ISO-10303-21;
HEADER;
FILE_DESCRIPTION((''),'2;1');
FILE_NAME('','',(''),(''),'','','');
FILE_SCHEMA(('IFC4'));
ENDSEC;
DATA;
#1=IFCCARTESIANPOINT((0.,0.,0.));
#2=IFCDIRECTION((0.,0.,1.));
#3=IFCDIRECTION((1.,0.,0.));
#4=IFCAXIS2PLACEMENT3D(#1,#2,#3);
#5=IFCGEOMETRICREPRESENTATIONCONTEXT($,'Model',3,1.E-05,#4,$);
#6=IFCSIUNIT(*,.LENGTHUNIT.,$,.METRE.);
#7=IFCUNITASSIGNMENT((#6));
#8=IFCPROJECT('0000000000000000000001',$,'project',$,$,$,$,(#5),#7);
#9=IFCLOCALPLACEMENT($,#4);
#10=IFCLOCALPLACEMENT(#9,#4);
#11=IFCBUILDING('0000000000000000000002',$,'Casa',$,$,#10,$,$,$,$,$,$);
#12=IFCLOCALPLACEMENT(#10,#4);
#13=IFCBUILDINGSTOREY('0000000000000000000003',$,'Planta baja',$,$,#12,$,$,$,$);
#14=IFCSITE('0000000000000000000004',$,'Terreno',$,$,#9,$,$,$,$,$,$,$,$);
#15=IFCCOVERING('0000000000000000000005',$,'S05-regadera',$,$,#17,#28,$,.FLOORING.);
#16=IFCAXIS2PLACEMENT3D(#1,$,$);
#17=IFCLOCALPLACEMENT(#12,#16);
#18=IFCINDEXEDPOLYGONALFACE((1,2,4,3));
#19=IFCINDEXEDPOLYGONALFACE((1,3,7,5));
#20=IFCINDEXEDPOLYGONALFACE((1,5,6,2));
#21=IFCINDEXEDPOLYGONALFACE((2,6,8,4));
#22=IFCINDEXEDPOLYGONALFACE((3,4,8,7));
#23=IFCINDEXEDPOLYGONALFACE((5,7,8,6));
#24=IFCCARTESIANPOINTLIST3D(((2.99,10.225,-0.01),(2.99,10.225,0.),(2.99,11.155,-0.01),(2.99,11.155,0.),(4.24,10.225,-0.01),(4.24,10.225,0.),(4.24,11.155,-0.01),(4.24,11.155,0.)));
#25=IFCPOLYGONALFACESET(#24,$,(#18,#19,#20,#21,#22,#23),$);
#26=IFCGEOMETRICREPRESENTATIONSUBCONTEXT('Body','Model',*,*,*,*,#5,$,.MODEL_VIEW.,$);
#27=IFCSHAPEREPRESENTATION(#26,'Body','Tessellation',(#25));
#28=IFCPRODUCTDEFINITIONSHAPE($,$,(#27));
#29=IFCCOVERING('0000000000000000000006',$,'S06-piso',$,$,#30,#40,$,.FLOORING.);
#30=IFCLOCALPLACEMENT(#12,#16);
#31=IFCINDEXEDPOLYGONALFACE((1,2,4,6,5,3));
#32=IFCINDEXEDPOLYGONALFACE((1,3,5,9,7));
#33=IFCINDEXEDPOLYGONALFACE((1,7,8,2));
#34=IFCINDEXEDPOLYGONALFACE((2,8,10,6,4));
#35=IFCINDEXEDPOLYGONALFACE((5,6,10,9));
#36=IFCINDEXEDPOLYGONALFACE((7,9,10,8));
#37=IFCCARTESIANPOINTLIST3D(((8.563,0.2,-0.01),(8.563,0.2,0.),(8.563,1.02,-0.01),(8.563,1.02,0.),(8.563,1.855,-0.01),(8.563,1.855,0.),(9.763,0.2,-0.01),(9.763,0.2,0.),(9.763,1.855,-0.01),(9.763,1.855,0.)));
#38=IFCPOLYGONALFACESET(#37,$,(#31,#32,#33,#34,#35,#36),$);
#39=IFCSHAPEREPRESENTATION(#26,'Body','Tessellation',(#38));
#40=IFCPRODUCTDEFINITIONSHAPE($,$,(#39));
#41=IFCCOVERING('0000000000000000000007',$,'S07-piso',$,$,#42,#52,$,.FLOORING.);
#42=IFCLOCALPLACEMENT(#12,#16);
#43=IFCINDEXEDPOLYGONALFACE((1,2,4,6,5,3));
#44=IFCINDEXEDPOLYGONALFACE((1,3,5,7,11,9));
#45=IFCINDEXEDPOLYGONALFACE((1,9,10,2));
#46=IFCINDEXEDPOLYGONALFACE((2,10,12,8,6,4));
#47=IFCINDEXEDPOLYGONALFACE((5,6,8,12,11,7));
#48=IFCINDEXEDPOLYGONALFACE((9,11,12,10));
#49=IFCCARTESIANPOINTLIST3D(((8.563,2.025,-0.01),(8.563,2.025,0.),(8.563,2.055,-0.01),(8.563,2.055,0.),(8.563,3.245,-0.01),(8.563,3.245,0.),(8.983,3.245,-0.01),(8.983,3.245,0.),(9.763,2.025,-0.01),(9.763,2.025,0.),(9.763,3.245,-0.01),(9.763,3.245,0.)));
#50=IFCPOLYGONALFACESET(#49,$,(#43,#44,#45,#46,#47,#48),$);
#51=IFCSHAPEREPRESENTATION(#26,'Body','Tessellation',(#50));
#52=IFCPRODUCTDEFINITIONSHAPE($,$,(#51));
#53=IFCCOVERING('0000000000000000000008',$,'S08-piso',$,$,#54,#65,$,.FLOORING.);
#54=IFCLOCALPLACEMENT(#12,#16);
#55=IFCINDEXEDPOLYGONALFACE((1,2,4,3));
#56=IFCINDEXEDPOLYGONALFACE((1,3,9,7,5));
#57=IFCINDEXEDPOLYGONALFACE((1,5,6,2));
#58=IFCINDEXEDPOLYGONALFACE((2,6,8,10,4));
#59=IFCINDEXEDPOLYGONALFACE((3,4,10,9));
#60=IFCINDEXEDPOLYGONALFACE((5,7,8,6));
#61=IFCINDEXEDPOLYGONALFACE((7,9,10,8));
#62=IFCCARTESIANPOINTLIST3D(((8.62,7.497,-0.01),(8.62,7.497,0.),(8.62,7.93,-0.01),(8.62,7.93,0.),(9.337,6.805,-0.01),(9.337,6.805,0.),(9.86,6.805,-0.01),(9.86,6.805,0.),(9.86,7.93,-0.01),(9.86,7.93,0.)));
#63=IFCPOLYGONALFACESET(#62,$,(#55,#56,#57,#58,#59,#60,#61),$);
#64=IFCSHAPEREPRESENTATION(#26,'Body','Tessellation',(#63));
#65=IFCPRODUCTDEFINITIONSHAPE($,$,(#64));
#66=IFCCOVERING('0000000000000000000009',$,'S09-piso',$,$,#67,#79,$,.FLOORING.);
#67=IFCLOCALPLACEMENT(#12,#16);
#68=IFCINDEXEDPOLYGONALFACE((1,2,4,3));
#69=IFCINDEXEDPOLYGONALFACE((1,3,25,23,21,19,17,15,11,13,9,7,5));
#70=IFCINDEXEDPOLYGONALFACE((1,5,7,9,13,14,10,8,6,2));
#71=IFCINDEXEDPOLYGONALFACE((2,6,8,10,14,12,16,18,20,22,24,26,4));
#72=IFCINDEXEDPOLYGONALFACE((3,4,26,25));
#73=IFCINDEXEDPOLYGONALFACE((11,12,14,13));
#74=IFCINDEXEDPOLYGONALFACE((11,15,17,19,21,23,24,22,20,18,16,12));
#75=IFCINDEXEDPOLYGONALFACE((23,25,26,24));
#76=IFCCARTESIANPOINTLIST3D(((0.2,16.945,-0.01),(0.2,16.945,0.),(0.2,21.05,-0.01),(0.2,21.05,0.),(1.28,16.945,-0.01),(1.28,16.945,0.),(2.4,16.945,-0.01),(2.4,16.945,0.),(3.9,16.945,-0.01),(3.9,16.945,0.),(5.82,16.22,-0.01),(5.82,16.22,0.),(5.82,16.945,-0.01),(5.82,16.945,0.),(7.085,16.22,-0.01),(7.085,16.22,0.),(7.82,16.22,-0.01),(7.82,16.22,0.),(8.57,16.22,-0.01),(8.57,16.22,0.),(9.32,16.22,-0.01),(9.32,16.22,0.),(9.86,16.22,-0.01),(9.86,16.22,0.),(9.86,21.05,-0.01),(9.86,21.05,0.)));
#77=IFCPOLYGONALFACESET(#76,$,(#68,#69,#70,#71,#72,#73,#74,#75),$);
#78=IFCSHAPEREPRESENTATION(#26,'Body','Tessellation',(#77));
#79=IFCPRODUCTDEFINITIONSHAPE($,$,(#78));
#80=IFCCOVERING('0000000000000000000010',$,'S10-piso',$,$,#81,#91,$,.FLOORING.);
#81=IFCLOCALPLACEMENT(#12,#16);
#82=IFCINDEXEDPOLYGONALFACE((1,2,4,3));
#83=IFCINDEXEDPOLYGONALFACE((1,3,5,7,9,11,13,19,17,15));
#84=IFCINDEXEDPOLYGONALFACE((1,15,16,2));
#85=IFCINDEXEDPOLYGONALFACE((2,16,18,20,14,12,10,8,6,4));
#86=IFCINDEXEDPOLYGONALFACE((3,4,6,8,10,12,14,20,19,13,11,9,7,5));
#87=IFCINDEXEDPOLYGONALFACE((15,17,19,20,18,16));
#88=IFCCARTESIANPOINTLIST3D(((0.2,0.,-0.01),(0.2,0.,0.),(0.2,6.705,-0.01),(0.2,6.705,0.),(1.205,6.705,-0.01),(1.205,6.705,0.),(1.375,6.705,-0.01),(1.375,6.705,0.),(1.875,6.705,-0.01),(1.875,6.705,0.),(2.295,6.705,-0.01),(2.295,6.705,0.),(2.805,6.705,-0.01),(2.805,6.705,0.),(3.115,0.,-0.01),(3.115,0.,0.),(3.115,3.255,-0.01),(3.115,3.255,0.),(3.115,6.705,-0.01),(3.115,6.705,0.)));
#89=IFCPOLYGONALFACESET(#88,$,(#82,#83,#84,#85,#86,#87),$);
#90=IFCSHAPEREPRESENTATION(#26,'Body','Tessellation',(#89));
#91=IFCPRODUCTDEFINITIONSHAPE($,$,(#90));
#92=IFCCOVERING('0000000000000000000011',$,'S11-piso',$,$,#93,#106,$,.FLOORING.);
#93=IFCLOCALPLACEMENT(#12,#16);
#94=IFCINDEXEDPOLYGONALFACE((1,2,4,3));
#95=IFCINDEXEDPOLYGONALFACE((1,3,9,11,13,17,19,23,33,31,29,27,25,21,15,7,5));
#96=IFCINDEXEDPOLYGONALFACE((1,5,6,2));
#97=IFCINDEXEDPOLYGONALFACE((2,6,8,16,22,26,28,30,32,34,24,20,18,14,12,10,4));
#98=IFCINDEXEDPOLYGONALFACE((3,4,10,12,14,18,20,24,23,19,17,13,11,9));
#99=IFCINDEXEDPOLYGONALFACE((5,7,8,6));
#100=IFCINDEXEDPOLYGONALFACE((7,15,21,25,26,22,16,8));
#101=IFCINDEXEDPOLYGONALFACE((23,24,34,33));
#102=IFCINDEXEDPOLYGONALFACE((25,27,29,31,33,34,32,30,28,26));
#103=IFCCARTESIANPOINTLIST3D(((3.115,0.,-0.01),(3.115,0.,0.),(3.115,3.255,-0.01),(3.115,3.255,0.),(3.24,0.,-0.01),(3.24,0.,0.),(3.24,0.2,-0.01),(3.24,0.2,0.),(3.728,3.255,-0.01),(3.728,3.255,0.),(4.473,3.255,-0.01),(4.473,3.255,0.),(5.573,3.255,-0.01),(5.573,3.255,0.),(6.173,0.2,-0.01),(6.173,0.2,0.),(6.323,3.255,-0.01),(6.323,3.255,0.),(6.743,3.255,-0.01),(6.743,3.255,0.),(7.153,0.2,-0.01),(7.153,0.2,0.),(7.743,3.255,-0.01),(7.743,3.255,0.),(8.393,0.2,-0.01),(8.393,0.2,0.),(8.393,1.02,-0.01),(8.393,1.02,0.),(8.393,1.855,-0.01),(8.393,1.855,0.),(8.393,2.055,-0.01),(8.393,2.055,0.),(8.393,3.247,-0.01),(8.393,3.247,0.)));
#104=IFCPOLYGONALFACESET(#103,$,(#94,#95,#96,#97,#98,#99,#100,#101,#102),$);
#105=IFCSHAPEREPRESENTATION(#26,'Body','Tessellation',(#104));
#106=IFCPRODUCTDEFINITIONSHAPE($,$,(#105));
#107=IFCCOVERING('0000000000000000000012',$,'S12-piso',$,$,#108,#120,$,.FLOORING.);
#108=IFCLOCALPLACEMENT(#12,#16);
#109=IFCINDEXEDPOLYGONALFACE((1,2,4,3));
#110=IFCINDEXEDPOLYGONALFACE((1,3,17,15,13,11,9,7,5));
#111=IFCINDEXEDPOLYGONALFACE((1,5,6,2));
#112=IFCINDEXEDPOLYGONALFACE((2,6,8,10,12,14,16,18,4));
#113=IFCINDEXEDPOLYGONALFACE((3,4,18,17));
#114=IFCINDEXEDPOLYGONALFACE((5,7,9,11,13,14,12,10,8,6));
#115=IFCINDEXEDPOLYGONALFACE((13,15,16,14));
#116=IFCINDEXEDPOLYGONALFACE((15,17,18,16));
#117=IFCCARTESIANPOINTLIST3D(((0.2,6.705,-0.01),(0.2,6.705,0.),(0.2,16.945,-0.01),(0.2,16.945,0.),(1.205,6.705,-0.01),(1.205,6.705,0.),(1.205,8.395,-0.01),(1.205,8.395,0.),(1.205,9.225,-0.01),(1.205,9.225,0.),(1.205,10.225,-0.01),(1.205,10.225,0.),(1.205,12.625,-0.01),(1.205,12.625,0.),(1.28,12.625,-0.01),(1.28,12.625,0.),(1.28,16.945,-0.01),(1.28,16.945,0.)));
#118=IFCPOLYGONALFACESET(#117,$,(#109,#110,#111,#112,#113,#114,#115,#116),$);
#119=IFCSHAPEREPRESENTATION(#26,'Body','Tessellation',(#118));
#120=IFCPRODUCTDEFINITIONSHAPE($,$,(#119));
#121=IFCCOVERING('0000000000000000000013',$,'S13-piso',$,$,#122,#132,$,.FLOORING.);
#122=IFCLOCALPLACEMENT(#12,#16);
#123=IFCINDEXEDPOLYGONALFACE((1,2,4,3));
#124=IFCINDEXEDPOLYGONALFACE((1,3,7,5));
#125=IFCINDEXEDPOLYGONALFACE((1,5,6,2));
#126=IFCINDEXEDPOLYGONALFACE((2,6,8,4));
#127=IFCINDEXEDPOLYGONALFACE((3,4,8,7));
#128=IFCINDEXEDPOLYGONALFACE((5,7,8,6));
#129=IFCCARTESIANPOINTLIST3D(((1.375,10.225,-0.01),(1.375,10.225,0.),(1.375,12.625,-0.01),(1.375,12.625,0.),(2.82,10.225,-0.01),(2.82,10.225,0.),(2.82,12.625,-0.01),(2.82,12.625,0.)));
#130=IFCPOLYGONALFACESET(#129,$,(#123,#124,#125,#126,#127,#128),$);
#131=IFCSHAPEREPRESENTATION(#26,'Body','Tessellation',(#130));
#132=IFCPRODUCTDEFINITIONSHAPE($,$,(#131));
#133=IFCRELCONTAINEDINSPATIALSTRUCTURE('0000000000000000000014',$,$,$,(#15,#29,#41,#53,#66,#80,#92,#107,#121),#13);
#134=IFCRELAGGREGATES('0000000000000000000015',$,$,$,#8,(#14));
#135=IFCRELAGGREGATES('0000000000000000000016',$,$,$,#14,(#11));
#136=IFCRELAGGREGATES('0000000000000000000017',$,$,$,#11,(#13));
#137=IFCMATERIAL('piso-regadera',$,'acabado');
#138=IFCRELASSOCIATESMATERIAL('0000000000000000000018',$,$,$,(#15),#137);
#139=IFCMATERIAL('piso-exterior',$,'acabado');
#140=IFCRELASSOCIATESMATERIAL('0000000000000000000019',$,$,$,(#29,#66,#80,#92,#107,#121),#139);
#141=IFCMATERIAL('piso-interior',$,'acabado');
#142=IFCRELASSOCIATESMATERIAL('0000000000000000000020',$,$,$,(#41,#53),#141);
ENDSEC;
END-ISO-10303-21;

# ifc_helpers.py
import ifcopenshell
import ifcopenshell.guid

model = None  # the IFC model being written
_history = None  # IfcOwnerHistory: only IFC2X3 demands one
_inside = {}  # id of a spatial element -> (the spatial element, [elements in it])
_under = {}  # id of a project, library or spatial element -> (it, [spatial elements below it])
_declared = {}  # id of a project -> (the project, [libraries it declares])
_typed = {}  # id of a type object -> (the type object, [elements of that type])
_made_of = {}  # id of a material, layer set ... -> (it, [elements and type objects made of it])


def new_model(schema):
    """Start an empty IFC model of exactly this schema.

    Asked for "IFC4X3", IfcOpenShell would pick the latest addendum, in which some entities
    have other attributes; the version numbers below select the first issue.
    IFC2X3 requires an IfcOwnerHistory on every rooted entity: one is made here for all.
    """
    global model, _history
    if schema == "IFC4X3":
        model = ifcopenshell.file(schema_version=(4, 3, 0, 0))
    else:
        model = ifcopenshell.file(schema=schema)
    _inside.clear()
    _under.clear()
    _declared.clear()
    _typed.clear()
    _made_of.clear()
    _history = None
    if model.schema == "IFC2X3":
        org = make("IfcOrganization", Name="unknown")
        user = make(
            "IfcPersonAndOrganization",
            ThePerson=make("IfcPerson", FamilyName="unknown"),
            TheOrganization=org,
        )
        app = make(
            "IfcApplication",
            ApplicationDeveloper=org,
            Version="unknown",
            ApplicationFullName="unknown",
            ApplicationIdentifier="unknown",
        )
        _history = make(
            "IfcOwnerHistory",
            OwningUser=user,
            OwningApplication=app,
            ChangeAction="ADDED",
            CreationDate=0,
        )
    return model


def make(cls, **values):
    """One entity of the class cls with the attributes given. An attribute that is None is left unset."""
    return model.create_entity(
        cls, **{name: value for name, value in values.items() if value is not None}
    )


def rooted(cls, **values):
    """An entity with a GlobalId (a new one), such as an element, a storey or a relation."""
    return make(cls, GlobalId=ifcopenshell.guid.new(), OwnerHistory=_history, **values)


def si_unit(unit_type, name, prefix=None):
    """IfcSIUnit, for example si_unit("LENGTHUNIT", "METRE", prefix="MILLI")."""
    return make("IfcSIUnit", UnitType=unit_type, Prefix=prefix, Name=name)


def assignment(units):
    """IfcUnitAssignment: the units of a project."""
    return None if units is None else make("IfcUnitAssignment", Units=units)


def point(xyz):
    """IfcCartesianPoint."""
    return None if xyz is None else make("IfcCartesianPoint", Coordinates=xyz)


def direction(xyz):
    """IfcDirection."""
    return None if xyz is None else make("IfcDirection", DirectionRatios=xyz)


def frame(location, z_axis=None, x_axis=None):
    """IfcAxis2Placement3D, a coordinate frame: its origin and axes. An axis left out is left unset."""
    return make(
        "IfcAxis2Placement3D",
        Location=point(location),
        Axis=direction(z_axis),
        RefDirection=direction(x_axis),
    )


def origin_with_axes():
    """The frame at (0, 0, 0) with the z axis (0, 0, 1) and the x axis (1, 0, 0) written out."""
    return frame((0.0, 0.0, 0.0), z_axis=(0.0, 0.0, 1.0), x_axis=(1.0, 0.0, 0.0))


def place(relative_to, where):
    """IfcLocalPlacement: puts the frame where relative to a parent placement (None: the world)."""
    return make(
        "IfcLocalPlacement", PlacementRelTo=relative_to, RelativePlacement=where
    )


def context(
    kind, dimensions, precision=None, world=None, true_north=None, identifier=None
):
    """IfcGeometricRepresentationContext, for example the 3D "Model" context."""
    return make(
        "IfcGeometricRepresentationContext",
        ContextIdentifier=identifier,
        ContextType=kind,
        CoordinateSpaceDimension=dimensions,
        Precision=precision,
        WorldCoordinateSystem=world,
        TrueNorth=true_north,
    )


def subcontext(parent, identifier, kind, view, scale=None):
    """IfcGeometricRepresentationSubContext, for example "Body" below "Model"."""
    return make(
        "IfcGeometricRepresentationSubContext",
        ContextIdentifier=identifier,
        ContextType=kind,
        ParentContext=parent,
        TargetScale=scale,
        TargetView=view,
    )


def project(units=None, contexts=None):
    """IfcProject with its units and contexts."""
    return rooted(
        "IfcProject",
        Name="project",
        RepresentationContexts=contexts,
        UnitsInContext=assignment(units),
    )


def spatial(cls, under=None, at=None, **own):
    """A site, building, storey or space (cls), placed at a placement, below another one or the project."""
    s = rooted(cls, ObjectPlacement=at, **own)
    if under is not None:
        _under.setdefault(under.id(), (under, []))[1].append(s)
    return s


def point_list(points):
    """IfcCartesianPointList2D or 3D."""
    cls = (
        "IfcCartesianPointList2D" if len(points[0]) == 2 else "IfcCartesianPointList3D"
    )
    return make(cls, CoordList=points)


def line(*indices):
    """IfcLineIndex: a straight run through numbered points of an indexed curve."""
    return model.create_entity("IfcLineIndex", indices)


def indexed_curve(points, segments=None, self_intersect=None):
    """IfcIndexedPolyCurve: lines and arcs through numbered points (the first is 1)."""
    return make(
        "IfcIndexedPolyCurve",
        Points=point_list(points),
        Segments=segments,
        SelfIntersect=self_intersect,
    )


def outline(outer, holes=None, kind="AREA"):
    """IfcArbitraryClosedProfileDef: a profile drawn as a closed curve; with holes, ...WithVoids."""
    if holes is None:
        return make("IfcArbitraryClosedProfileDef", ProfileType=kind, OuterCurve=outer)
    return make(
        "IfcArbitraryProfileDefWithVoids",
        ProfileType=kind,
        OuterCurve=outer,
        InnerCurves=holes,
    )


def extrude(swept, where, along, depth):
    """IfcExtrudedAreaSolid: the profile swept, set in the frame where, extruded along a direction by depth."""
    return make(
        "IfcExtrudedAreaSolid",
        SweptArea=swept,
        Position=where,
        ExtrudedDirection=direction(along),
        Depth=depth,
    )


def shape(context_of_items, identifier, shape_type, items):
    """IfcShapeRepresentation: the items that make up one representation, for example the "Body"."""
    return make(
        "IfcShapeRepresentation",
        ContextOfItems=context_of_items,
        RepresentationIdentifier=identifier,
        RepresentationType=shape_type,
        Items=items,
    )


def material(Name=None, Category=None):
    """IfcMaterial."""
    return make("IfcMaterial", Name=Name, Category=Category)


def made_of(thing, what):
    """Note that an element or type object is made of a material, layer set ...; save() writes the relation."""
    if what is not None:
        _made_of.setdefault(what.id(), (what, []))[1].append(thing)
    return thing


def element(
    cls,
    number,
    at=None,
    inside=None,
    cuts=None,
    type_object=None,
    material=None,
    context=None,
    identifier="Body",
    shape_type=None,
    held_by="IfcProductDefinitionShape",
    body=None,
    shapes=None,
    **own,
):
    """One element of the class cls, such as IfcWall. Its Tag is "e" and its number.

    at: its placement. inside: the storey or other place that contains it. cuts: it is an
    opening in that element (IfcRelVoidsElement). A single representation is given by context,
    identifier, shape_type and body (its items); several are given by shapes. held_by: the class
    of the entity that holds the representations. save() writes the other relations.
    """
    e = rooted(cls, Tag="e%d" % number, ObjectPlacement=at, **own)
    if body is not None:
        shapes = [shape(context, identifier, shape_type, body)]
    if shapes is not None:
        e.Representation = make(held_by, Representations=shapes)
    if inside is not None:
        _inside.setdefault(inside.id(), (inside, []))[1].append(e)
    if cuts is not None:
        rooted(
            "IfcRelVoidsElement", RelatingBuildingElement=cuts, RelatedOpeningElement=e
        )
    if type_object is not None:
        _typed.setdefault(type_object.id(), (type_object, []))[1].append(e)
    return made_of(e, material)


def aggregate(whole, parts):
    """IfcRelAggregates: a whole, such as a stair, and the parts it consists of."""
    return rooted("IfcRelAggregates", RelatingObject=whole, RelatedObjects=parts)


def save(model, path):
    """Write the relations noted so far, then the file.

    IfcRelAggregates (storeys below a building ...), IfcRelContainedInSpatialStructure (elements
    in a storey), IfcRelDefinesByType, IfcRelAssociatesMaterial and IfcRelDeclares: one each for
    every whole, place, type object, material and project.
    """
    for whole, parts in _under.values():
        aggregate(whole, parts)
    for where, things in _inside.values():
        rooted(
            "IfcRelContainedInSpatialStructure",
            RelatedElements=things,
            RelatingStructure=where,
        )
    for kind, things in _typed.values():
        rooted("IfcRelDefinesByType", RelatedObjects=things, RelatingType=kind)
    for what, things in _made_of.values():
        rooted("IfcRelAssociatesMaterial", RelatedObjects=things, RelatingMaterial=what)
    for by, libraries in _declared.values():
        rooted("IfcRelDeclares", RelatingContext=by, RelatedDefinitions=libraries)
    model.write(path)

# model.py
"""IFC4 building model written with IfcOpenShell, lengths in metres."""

from ifc_helpers import new_model, si_unit, frame, origin_with_axes, place, context, subcontext, project, spatial, line, indexed_curve, outline, extrude, material, element, save


model = new_model("IFC4")

# Units and contexts
model_context = context("Model", 3, precision=1e-05, world=origin_with_axes())
body_context = subcontext(model_context, "Body", "Model", "MODEL_VIEW")
ifc_project = project(units=[si_unit("LENGTHUNIT", "METRE")], contexts=[model_context])

# Site, building, storey
site_placement = place(None, origin_with_axes())
site = spatial("IfcSite", under=ifc_project, at=site_placement, Name="Terreno")
building_placement = place(site_placement, origin_with_axes())
building = spatial("IfcBuilding", under=site, at=building_placement, Name="Casa")
storey_placement = place(building_placement, origin_with_axes())
storey = spatial("IfcBuildingStorey", under=building, at=storey_placement, Name="Planta baja")

# Coverings
ifc_material_1 = material(Name="piso-interior", Category="acabado")
ifc_material_2 = material(Name="piso-regadera", Category="acabado")
covering_1_placement = place(storey_placement, origin_with_axes())
element("IfcCovering", 1, at=covering_1_placement, inside=storey, material=ifc_material_2, Name="S05-regadera", PredefinedType="FLOORING", context=body_context, shape_type="SweptSolid", body=[
    extrude(outline(indexed_curve([(4.24, 10.225), (2.99, 10.225), (2.99, 11.155), (4.24, 11.155)], segments=[line(1, 2, 3, 4, 1)])), frame((0.0, 0.0, -0.01), z_axis=(0.0, 0.0, 1.0), x_axis=(1.0, 0.0, 0.0)), (0.0, 0.0, 1.0), 0.01),
])
ifc_material_3 = material(Name="piso-exterior", Category="acabado")
covering_2_placement = place(storey_placement, origin_with_axes())
element("IfcCovering", 2, at=covering_2_placement, inside=storey, material=ifc_material_3, Name="S06-piso", PredefinedType="FLOORING", context=body_context, shape_type="SweptSolid", body=[
    extrude(outline(indexed_curve([(8.563, 1.02), (8.563, 1.855), (9.763, 1.855), (9.763, 0.2), (8.563, 0.2)], segments=[line(1, 2, 3, 4, 5, 1)])), frame((0.0, 0.0, -0.01), z_axis=(0.0, 0.0, 1.0), x_axis=(1.0, 0.0, 0.0)), (0.0, 0.0, 1.0), 0.01),
])
covering_3_placement = place(storey_placement, origin_with_axes())
element("IfcCovering", 3, at=covering_3_placement, inside=storey, material=ifc_material_1, Name="S07-piso", PredefinedType="FLOORING", context=body_context, shape_type="SweptSolid", body=[
    extrude(outline(indexed_curve([(8.983, 3.245), (9.763, 3.245), (9.763, 2.025), (8.563, 2.025), (8.563, 2.055), (8.563, 3.245)], segments=[line(1, 2, 3, 4, 5, 6, 1)])), frame((0.0, 0.0, -0.01), z_axis=(0.0, 0.0, 1.0), x_axis=(1.0, 0.0, 0.0)), (0.0, 0.0, 1.0), 0.01),
])
covering_4_placement = place(storey_placement, origin_with_axes())
element("IfcCovering", 4, at=covering_4_placement, inside=storey, material=ifc_material_1, Name="S08-piso", PredefinedType="FLOORING", context=body_context, shape_type="SweptSolid", body=[
    extrude(outline(indexed_curve([(9.86, 6.805), (9.337, 6.805), (8.62, 7.497), (8.62, 7.93), (9.86, 7.93)], segments=[line(1, 2, 3, 4, 5, 1)])), frame((0.0, 0.0, -0.01), z_axis=(0.0, 0.0, 1.0), x_axis=(1.0, 0.0, 0.0)), (0.0, 0.0, 1.0), 0.01),
])
covering_5_placement = place(storey_placement, origin_with_axes())
element("IfcCovering", 5, at=covering_5_placement, inside=storey, material=ifc_material_3, Name="S09-piso", PredefinedType="FLOORING", context=body_context, shape_type="SweptSolid", body=[
    extrude(outline(indexed_curve([(9.86, 16.22), (9.32, 16.22), (8.57, 16.22), (7.82, 16.22), (7.085, 16.22), (5.82, 16.22), (5.82, 16.945), (3.9, 16.945), (2.4, 16.945), (1.28, 16.945), (0.2, 16.945), (0.2, 21.05), (9.86, 21.05)], segments=[line(1, 2, 3, 4, 5, 6, 7, 8, 9, 10, 11, 12, 13, 1)])), frame((0.0, 0.0, -0.01), z_axis=(0.0, 0.0, 1.0), x_axis=(1.0, 0.0, 0.0)), (0.0, 0.0, 1.0), 0.01),
])
covering_6_placement = place(storey_placement, origin_with_axes())
element("IfcCovering", 6, at=covering_6_placement, inside=storey, material=ifc_material_3, Name="S10-piso", PredefinedType="FLOORING", context=body_context, shape_type="SweptSolid", body=[
    extrude(outline(indexed_curve([(1.875, 6.705), (2.295, 6.705), (2.805, 6.705), (3.115, 6.705), (3.115, 3.255), (3.115, 0.0), (0.2, 0.0), (0.2, 6.705), (1.205, 6.705), (1.375, 6.705)], segments=[line(1, 2, 3, 4, 5, 6, 7, 8, 9, 10, 1)])), frame((0.0, 0.0, -0.01), z_axis=(0.0, 0.0, 1.0), x_axis=(1.0, 0.0, 0.0)), (0.0, 0.0, 1.0), 0.01),
])
covering_7_placement = place(storey_placement, origin_with_axes())
element("IfcCovering", 7, at=covering_7_placement, inside=storey, material=ifc_material_3, Name="S11-piso", PredefinedType="FLOORING", context=body_context, shape_type="SweptSolid", body=[
    extrude(outline(indexed_curve([(6.323, 3.255), (6.743, 3.255), (7.743, 3.255), (8.393, 3.247), (8.393, 2.055), (8.393, 1.855), (8.393, 1.02), (8.393, 0.2), (7.153, 0.2), (6.173, 0.2), (3.24, 0.2), (3.24, 0.0), (3.115, 0.0), (3.115, 3.255), (3.728, 3.255), (4.473, 3.255), (5.573, 3.255)], segments=[line(1, 2, 3, 4, 5, 6, 7, 8, 9, 10, 11, 12, 13, 14, 15, 16, 17, 1)])), frame((0.0, 0.0, -0.01), z_axis=(0.0, 0.0, 1.0), x_axis=(1.0, 0.0, 0.0)), (0.0, 0.0, 1.0), 0.01),
])
covering_8_placement = place(storey_placement, origin_with_axes())
element("IfcCovering", 8, at=covering_8_placement, inside=storey, material=ifc_material_3, Name="S12-piso", PredefinedType="FLOORING", context=body_context, shape_type="SweptSolid", body=[
    extrude(outline(indexed_curve([(1.205, 9.225), (1.205, 8.395), (1.205, 6.705), (0.2, 6.705), (0.2, 16.945), (1.28, 16.945), (1.28, 12.625), (1.205, 12.625), (1.205, 10.225)], segments=[line(1, 2, 3, 4, 5, 6, 7, 8, 9, 1)])), frame((0.0, 0.0, -0.01), z_axis=(0.0, 0.0, 1.0), x_axis=(1.0, 0.0, 0.0)), (0.0, 0.0, 1.0), 0.01),
])
covering_9_placement = place(storey_placement, origin_with_axes())
element("IfcCovering", 9, at=covering_9_placement, inside=storey, material=ifc_material_3, Name="S13-piso", PredefinedType="FLOORING", context=body_context, shape_type="SweptSolid", body=[
    extrude(outline(indexed_curve([(2.82, 10.225), (1.375, 10.225), (1.375, 12.625), (2.82, 12.625)], segments=[line(1, 2, 3, 4, 1)])), frame((0.0, 0.0, -0.01), z_axis=(0.0, 0.0, 1.0), x_axis=(1.0, 0.0, 0.0)), (0.0, 0.0, 1.0), 0.01),
])

save(model, "model.ifc")
